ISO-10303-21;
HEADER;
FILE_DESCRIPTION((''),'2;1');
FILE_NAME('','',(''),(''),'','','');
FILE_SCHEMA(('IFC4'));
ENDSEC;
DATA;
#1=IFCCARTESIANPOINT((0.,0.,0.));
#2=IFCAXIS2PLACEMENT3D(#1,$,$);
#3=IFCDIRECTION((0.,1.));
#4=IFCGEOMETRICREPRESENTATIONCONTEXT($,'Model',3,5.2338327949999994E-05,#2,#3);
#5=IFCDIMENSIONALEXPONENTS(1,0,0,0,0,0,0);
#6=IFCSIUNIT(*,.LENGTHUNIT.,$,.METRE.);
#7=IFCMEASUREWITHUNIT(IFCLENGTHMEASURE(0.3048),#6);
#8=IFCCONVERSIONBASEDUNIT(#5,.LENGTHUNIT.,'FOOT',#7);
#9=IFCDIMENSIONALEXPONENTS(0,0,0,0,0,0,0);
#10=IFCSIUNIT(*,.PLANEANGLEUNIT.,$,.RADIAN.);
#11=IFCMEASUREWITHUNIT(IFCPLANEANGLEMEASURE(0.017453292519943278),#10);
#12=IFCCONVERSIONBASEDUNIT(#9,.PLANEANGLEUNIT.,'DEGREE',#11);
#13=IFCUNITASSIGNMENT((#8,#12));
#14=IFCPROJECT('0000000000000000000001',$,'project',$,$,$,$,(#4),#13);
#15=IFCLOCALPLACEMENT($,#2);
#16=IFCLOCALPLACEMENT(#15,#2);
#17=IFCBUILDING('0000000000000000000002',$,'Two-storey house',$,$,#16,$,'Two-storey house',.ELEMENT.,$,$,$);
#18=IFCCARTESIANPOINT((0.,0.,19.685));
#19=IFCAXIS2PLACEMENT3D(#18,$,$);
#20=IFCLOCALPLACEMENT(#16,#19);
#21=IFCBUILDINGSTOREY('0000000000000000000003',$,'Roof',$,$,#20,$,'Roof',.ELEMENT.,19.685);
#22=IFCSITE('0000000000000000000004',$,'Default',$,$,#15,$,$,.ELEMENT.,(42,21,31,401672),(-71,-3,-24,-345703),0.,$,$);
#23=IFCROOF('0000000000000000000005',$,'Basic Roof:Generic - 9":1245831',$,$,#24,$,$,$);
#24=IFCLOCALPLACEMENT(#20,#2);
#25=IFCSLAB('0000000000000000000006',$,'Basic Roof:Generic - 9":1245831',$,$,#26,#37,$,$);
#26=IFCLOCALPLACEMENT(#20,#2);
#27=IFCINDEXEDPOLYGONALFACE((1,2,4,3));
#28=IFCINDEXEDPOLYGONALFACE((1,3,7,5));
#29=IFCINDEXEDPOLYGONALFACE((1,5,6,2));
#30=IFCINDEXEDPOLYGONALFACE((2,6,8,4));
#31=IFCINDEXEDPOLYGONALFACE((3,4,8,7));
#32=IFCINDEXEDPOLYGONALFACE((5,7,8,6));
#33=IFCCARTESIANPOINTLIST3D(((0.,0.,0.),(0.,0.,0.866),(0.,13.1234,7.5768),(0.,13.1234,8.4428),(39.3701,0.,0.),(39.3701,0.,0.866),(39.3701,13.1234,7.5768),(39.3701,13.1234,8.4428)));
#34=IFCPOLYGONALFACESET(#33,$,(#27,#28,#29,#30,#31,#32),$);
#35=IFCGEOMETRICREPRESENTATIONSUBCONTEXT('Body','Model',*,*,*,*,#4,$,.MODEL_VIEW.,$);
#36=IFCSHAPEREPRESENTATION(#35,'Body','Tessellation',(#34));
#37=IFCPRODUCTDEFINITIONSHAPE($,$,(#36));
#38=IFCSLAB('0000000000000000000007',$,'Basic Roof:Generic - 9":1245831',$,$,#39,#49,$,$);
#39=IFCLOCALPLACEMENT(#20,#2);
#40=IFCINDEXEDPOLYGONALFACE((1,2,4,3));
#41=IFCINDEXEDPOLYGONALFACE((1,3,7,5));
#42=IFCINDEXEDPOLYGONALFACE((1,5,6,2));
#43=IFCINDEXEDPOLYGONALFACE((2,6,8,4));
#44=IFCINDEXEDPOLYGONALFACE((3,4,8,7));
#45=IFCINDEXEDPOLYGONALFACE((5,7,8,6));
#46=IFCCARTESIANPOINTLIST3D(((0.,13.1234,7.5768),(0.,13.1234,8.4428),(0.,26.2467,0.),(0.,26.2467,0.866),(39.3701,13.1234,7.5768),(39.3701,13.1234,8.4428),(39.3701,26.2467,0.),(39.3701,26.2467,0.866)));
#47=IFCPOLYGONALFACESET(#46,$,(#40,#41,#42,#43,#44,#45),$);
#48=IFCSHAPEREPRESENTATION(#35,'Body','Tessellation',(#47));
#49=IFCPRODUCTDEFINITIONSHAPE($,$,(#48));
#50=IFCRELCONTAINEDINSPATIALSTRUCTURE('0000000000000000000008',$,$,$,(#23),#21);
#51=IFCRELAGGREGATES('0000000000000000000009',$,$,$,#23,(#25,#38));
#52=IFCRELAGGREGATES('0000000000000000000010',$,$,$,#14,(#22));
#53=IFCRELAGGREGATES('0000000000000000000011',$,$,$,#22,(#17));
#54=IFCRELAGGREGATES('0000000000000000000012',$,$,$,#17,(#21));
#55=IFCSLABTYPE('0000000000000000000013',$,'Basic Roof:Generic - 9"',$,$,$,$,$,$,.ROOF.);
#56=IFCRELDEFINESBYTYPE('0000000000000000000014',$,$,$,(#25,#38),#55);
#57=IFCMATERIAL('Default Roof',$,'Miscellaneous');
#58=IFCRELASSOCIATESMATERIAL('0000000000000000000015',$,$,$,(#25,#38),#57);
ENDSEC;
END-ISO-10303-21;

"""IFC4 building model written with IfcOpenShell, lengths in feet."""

from ifc_helpers import new_model, entity, si_unit, converted_unit, direction, frame, origin, place, context, subcontext, project, spatial, indexed_curve, outline, extrude, material, type_object, element, aggregate, save


model = new_model("IFC4")

# Units and contexts
model_context = context("Model", 3, precision=5.2338327949999994e-05, world=origin(), true_north=direction((0.0, 1.0)))
body_context = subcontext(model_context, "Body", "Model", "MODEL_VIEW")
ifc_project = project(units=[converted_unit("LENGTHUNIT", "FOOT", entity("IfcLengthMeasure", 0.3048), si_unit("LENGTHUNIT", "METRE"), dimensions=[1, 0, 0, 0, 0, 0, 0]), converted_unit("PLANEANGLEUNIT", "DEGREE", entity("IfcPlaneAngleMeasure", 0.017453292519943278), si_unit("PLANEANGLEUNIT", "RADIAN"), dimensions=[0, 0, 0, 0, 0, 0, 0])], contexts=[model_context])

# Site, building, storey
site_placement = place(None, origin())
site = spatial("IfcSite", under=ifc_project, at=site_placement, Name="Default", CompositionType="ELEMENT", RefLatitude=(42, 21, 31, 401672), RefLongitude=(-71, -3, -24, -345703), RefElevation=0.0)
building_placement = place(site_placement, origin())
building = spatial("IfcBuilding", under=site, at=building_placement, Name="Two-storey house", LongName="Two-storey house", CompositionType="ELEMENT")
storey_placement = place(building_placement, frame((0.0, 0.0, 19.685)))
storey = spatial("IfcBuildingStorey", under=building, at=storey_placement, Name="Roof", LongName="Roof", CompositionType="ELEMENT", Elevation=19.685)

# Roof, slabs
roof_placement = place(storey_placement, origin())
roof = element("IfcRoof", 1, at=roof_placement, inside=storey, Name="Basic Roof:Generic - 9\":1245831")
ifc_material = material(Name="Default Roof", Category="Miscellaneous")
slab_type = type_object("IfcSlabType", Name="Basic Roof:Generic - 9\"", PredefinedType="ROOF")
slab_1_placement = place(roof_placement, origin())
slab_1 = element("IfcSlab", 2, at=slab_1_placement, type_object=slab_type, material=ifc_material, Name="Basic Roof:Generic - 9\":1245831", context=body_context, shape_type="SweptSolid", body=[
    extrude(outline(indexed_curve([(19.685, 7.5768), (-19.685, 7.5768), (-19.685, -7.5768), (19.685, -7.5768), (19.685, 7.5768)], self_intersect=False)), frame((19.685, 6.5617, 3.7884), z_axis=(0.0, -0.5, 0.866025), x_axis=(1.0, 0.0, 0.0)), (0.0, 0.5, 0.866025), 0.866),
])
slab_2_placement = place(roof_placement, origin())
slab_2 = element("IfcSlab", 3, at=slab_2_placement, type_object=slab_type, material=ifc_material, Name="Basic Roof:Generic - 9\":1245831", context=body_context, shape_type="SweptSolid", body=[
    extrude(outline(indexed_curve([(-19.685, 7.5768), (-19.685, -7.5768), (19.685, -7.5768), (19.685, 7.5768), (-19.685, 7.5768)], self_intersect=False)), frame((19.685, 19.685, 3.7884), z_axis=(0.0, 0.5, 0.866025), x_axis=(1.0, 0.0, 0.0)), (0.0, -0.5, 0.866025), 0.866),
])
aggregate(roof, [slab_1, slab_2])

save(model, "model.ifc")
